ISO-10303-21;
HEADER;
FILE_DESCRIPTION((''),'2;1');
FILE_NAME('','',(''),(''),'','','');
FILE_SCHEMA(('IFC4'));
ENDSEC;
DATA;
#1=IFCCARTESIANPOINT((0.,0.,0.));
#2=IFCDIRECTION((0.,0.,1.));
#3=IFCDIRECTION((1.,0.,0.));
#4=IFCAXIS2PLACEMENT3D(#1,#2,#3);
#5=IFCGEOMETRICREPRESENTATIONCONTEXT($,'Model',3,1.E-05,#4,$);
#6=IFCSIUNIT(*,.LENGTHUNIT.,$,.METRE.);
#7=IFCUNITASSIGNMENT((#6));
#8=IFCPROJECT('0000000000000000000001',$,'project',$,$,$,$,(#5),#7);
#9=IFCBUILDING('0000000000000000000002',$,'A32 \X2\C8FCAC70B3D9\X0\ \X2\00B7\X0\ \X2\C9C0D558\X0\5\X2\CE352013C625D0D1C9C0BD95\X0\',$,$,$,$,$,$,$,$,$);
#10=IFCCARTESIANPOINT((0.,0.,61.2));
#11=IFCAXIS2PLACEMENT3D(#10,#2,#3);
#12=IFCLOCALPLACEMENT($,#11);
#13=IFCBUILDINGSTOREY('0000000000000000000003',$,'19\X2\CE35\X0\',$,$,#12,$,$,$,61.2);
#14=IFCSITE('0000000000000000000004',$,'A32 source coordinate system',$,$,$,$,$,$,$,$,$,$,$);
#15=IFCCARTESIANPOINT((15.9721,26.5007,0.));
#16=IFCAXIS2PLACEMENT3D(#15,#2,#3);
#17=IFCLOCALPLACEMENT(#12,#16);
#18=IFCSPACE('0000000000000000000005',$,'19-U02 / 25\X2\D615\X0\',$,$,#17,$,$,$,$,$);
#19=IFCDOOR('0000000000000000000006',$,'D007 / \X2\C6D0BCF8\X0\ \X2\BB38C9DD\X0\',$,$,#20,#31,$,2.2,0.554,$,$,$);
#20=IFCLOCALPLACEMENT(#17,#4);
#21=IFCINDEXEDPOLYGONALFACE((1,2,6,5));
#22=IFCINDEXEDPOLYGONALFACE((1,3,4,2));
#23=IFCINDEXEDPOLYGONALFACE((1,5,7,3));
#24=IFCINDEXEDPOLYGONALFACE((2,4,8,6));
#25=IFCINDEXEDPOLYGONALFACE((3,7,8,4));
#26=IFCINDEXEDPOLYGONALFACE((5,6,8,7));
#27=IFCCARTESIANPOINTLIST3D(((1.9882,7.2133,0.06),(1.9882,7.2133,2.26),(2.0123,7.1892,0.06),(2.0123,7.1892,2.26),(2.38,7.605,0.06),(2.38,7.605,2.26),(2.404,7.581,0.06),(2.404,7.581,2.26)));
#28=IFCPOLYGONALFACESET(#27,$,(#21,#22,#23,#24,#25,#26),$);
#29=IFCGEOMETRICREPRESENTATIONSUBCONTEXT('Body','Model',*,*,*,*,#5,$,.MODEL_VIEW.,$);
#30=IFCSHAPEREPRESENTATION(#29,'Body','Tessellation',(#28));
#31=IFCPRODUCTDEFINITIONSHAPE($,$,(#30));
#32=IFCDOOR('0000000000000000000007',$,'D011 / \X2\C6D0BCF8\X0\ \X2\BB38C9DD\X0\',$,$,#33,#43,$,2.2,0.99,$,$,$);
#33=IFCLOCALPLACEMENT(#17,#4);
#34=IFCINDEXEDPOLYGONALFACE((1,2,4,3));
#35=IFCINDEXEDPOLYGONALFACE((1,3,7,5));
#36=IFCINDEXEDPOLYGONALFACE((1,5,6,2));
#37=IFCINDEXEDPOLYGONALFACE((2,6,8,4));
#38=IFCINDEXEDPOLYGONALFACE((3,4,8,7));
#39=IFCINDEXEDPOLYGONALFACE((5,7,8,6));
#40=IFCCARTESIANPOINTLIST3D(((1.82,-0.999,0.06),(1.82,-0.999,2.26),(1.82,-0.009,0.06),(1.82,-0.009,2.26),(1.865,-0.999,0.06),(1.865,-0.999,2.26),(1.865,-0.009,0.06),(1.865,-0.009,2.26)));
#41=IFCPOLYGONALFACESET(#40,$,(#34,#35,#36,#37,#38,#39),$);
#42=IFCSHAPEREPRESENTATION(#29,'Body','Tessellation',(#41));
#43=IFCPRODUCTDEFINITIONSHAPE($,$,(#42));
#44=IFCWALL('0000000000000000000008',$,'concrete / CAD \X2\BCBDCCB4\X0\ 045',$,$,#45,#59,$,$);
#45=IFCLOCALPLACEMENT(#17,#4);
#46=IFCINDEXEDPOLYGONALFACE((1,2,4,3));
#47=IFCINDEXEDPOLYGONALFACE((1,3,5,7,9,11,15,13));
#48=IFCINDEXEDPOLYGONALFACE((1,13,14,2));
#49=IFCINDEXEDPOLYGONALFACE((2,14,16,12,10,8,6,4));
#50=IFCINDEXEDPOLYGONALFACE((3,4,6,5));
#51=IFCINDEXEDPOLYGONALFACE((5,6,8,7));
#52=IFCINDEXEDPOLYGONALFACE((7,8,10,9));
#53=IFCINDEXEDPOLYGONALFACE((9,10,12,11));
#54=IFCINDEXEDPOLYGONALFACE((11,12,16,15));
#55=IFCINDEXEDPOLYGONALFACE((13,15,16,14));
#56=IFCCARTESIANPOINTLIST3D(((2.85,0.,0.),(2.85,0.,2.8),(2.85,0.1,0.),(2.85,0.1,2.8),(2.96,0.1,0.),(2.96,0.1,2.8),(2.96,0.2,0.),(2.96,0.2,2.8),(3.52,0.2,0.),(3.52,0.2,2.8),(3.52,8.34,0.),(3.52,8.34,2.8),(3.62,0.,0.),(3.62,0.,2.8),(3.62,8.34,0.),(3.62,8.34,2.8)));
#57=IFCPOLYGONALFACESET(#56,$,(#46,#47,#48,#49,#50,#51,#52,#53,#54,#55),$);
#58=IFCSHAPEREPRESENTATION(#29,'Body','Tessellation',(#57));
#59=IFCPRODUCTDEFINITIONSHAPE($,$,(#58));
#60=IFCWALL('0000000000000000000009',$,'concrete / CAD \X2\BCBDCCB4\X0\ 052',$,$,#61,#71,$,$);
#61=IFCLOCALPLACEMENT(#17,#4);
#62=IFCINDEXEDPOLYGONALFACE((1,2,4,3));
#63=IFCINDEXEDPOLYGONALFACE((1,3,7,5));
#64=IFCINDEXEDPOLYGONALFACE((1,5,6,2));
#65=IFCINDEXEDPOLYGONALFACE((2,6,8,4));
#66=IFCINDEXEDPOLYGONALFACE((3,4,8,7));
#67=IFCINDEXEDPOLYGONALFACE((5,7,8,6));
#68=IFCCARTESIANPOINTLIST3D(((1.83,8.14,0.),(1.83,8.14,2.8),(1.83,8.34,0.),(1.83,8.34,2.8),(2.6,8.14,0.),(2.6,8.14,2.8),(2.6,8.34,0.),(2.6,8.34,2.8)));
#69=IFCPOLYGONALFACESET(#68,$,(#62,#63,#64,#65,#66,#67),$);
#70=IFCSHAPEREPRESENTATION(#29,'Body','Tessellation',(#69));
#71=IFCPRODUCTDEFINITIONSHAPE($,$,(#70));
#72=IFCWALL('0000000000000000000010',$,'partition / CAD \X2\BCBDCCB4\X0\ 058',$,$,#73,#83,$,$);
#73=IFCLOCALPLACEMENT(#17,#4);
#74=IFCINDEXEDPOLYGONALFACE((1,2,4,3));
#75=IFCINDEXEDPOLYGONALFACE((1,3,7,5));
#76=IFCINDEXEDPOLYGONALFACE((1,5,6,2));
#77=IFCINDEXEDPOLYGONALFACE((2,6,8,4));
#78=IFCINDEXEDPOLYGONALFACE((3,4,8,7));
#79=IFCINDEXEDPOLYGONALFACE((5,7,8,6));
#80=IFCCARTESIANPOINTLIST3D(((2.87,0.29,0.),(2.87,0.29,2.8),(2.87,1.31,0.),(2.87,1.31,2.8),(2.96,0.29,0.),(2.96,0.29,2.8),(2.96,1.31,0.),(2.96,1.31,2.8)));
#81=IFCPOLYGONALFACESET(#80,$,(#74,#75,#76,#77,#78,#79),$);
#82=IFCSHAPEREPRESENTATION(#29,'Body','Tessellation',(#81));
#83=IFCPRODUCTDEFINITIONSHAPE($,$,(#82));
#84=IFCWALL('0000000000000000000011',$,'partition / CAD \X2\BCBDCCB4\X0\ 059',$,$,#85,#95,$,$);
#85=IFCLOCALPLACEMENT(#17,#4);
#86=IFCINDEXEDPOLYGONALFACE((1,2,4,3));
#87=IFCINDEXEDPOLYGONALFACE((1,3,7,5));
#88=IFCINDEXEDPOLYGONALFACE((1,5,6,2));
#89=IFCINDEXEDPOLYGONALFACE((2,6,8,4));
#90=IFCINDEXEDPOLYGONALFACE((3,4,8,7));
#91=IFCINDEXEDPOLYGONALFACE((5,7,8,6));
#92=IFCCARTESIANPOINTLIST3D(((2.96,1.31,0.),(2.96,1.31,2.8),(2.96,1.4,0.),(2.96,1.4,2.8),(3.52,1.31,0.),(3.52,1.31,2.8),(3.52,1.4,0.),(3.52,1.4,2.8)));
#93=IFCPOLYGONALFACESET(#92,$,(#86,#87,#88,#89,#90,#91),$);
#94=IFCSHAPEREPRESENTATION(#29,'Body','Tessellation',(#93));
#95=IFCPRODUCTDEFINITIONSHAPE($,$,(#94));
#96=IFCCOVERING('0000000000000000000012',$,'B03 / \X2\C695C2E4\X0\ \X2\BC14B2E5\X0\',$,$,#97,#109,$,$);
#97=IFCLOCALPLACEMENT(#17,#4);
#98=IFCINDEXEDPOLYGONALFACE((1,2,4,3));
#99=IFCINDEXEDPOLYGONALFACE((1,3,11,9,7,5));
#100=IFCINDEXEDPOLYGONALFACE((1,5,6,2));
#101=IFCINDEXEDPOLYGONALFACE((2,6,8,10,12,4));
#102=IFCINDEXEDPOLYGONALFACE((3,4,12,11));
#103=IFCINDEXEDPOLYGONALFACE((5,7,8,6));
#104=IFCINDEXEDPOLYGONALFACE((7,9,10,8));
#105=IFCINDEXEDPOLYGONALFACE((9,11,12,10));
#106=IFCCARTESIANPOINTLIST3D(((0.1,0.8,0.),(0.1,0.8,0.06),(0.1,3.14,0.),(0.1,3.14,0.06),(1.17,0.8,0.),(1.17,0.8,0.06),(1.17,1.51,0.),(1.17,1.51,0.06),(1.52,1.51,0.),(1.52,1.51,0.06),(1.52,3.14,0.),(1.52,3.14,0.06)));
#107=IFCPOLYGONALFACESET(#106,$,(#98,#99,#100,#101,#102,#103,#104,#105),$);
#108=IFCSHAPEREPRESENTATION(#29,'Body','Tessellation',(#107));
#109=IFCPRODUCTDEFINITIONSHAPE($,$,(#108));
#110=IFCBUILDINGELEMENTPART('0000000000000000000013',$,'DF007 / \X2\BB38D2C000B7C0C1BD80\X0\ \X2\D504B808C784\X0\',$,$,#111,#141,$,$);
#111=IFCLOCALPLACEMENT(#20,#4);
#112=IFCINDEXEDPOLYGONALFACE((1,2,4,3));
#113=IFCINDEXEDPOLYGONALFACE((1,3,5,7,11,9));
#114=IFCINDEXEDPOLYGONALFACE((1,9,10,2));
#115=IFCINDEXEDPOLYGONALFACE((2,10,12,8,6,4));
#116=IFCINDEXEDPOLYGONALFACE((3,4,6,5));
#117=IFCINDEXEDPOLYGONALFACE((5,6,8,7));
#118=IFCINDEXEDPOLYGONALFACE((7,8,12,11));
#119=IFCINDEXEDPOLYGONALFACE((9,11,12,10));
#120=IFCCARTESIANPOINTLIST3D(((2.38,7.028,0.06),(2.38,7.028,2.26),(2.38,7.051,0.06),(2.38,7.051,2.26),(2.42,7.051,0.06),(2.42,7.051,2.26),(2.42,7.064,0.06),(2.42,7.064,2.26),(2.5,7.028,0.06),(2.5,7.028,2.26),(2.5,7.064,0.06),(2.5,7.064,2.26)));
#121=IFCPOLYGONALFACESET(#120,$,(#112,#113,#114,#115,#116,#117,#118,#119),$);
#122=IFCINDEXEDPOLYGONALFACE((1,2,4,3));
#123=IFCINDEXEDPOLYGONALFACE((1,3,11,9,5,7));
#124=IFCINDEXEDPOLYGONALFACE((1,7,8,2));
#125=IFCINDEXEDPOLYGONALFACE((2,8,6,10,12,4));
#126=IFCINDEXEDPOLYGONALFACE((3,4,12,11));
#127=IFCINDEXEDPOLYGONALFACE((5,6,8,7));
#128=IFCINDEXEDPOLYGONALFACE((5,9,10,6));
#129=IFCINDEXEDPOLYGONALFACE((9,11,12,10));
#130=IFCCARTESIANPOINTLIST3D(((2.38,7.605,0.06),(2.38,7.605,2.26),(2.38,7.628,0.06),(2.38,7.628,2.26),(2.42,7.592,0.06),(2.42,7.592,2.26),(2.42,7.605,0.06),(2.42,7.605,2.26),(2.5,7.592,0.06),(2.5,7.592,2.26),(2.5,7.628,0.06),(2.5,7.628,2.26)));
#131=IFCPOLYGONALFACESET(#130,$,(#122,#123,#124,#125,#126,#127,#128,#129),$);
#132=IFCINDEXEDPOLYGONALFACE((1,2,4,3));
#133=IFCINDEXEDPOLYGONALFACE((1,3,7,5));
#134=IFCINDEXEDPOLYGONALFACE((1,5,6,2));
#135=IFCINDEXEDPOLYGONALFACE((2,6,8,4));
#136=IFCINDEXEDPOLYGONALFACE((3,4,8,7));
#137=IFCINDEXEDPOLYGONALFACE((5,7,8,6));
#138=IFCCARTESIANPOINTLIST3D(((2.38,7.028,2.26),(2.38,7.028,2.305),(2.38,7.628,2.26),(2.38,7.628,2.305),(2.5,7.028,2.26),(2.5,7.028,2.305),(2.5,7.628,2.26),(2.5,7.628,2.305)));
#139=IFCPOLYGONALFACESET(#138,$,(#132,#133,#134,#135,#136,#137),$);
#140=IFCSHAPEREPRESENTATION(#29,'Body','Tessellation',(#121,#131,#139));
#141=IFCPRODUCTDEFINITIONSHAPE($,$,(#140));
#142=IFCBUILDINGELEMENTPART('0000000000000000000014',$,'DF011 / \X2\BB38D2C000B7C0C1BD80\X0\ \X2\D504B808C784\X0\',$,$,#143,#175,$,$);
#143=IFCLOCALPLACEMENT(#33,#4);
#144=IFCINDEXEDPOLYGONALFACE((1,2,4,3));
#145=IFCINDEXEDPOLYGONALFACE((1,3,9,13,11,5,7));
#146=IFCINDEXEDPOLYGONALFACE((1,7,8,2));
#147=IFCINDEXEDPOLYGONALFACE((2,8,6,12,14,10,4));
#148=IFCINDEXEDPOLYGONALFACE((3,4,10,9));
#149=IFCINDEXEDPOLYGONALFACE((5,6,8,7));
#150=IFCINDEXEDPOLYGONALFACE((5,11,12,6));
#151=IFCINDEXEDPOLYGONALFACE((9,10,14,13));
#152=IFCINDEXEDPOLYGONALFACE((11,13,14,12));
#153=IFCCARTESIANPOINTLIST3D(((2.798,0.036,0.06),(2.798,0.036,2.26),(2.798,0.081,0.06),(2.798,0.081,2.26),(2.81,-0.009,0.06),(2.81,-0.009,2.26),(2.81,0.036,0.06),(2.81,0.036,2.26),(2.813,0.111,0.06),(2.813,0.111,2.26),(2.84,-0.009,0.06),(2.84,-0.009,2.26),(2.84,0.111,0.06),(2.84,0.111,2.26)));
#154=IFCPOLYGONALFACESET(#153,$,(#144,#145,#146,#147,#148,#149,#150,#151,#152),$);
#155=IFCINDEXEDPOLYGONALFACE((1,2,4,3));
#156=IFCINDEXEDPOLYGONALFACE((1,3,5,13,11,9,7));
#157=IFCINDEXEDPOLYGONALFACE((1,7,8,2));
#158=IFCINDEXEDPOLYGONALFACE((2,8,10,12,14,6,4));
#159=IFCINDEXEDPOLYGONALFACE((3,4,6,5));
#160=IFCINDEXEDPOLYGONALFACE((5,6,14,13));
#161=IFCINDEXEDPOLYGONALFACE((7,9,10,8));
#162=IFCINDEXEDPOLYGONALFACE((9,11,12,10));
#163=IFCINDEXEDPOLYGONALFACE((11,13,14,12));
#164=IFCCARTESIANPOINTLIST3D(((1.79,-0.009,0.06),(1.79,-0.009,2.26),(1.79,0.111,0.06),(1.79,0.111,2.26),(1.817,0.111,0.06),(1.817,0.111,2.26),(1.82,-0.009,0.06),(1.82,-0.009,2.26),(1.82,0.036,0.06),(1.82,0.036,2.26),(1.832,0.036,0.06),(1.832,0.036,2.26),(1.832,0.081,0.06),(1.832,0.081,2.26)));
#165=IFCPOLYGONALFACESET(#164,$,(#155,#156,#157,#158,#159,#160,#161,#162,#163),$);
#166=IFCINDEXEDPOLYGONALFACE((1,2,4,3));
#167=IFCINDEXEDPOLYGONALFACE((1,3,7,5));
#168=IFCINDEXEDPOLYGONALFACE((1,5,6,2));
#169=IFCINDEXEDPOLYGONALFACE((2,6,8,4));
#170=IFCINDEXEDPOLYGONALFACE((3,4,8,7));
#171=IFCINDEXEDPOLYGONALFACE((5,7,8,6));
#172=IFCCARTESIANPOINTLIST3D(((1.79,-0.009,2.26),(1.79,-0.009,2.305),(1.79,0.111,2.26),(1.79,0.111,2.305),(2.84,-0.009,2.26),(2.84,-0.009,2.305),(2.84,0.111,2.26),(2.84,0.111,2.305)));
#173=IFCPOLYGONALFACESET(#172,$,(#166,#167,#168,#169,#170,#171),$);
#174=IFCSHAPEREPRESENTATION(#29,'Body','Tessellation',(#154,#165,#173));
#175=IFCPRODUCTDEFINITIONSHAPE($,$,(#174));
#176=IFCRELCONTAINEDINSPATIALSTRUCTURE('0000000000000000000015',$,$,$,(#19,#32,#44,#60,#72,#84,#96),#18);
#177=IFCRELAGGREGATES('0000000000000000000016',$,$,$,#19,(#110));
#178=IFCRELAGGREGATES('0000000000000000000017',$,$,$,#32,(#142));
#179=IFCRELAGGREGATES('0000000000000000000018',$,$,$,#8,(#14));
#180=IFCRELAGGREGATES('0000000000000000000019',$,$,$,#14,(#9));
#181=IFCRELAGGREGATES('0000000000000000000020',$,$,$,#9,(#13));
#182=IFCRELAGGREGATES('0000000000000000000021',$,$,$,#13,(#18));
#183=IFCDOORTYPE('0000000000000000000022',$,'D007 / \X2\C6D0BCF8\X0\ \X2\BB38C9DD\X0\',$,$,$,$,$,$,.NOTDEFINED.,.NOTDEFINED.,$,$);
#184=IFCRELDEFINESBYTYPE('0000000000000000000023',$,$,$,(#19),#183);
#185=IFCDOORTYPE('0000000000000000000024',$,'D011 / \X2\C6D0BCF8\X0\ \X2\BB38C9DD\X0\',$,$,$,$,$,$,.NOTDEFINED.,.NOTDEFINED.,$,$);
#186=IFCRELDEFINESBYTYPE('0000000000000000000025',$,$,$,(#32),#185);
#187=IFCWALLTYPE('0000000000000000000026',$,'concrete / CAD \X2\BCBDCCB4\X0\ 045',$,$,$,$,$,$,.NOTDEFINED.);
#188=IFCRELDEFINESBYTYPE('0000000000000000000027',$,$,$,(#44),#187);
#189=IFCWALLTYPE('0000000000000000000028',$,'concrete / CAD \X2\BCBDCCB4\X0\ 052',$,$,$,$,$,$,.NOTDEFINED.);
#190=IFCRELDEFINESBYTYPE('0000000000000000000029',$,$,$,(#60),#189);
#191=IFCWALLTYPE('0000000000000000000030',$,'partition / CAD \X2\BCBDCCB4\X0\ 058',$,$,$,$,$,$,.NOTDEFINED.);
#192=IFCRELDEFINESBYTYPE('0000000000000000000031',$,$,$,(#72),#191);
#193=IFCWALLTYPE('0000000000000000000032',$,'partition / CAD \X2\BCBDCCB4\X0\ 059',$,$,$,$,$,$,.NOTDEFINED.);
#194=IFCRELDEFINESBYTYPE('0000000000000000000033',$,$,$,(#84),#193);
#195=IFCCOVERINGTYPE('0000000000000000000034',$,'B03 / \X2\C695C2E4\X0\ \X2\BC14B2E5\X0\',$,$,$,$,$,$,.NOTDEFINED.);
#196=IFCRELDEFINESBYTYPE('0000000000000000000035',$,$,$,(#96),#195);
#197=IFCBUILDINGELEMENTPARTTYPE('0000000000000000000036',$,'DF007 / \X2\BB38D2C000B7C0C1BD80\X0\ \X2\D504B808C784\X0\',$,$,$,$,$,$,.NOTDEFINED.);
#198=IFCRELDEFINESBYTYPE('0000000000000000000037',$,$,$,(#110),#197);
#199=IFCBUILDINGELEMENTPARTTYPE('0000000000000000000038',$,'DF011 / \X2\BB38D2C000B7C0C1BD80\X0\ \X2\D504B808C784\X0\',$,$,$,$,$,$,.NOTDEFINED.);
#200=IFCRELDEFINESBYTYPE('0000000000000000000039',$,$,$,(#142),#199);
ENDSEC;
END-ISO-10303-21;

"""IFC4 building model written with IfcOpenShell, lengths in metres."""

from ifc_helpers import new_model, si_unit, frame, origin, origin_with_axes, place, context, subcontext, project, spatial, polyline, outline, extrude, source, transform, mapped, type_object, type_shapes, element, aggregate, save


model = new_model("IFC4")

# Units and contexts
model_context = context("Model", 3, precision=1e-05, world=origin_with_axes())
body_context = subcontext(model_context, "Body", "Model", "MODEL_VIEW")
ifc_project = project(units=[si_unit("LENGTHUNIT", "METRE")], contexts=[model_context])

# Site, building, storey, space
storey_placement = place(None, frame((0.0, 0.0, 61.2), z_axis=(0.0, 0.0, 1.0), x_axis=(1.0, 0.0, 0.0)))
space_placement = place(storey_placement, frame((15.9721, 26.5007, 0.0), z_axis=(0.0, 0.0, 1.0), x_axis=(1.0, 0.0, 0.0)))
site = spatial("IfcSite", under=ifc_project, Name="A32 source coordinate system")
building = spatial("IfcBuilding", under=site, Name="A32 주거동 · 지하5층–옥탑지붕")
storey = spatial("IfcBuildingStorey", under=building, at=storey_placement, Name="19층", Elevation=61.2)
space = spatial("IfcSpace", under=storey, at=space_placement, Name="19-U02 / 25형")

# Doors
door_type_1 = type_object("IfcDoorType", Name="D007 / 원본 문짝", OperationType="NOTDEFINED", PredefinedType="NOTDEFINED")
shared_shape_1 = source(origin(), body_context, "Body", "SweptSolid", [
    extrude(outline(polyline([(2.0123, 7.1892), (1.9882, 7.2133), (2.38, 7.605), (2.404, 7.581), (2.0123, 7.1892)])), frame((0.0, 0.0, 0.06)), (0.0, 0.0, 1.0), 2.2),
])
type_shapes(door_type_1, [shared_shape_1])
door_1_placement = place(space_placement, origin_with_axes())
door_1 = element("IfcDoor", 1, at=door_1_placement, inside=space, type_object=door_type_1, Name="D007 / 원본 문짝", OverallHeight=2.2, OverallWidth=0.554, context=body_context, shape_type="MappedRepresentation", body=[
    mapped(shared_shape_1, transform((0.0, 0.0, 0.0), scale=1.0)),
])
door_type_2 = type_object("IfcDoorType", Name="D011 / 원본 문짝", OperationType="NOTDEFINED", PredefinedType="NOTDEFINED")
shared_shape_2 = source(origin(), body_context, "Body", "SweptSolid", [
    extrude(outline(polyline([(1.865, -0.999), (1.82, -0.999), (1.82, -0.009), (1.865, -0.009), (1.865, -0.999)])), frame((0.0, 0.0, 0.06)), (0.0, 0.0, 1.0), 2.2),
])
type_shapes(door_type_2, [shared_shape_2])
door_2_placement = place(space_placement, origin_with_axes())
door_2 = element("IfcDoor", 2, at=door_2_placement, inside=space, type_object=door_type_2, Name="D011 / 원본 문짝", OverallHeight=2.2, OverallWidth=0.99, context=body_context, shape_type="MappedRepresentation", body=[
    mapped(shared_shape_2, transform((0.0, 0.0, 0.0), scale=1.0)),
])

# Walls
wall_type_1 = type_object("IfcWallType", Name="concrete / CAD 벽체 045", PredefinedType="NOTDEFINED")
shared_shape_3 = source(origin(), body_context, "Body", "SweptSolid", [
    extrude(outline(polyline([(2.96, 0.1), (2.96, 0.2), (3.52, 0.2), (3.52, 8.34), (3.72, 8.34), (3.72, 8.34), (3.62, 8.34), (3.62, 0.0), (2.85, 0.0), (2.85, 0.1), (2.96, 0.1)])), origin(), (0.0, 0.0, 1.0), 2.8),
])
type_shapes(wall_type_1, [shared_shape_3])
wall_1_placement = place(space_placement, origin_with_axes())
element("IfcWall", 3, at=wall_1_placement, inside=space, type_object=wall_type_1, Name="concrete / CAD 벽체 045", context=body_context, shape_type="MappedRepresentation", body=[
    mapped(shared_shape_3, transform((0.0, 0.0, 0.0), scale=1.0)),
])
wall_type_2 = type_object("IfcWallType", Name="concrete / CAD 벽체 052", PredefinedType="NOTDEFINED")
shared_shape_4 = source(origin(), body_context, "Body", "SweptSolid", [
    extrude(outline(polyline([(2.6, 8.14), (1.83, 8.14), (1.83, 8.34), (2.6, 8.34), (2.6, 8.14)])), origin(), (0.0, 0.0, 1.0), 2.8),
])
type_shapes(wall_type_2, [shared_shape_4])
wall_2_placement = place(space_placement, origin_with_axes())
element("IfcWall", 4, at=wall_2_placement, inside=space, type_object=wall_type_2, Name="concrete / CAD 벽체 052", context=body_context, shape_type="MappedRepresentation", body=[
    mapped(shared_shape_4, transform((0.0, 0.0, 0.0), scale=1.0)),
])
wall_type_3 = type_object("IfcWallType", Name="partition / CAD 벽체 058", PredefinedType="NOTDEFINED")
shared_shape_5 = source(origin(), body_context, "Body", "SweptSolid", [
    extrude(outline(polyline([(2.96, 1.31), (2.96, 0.29), (2.87, 0.29), (2.87, 1.31), (2.96, 1.31)])), origin(), (0.0, 0.0, 1.0), 2.8),
])
type_shapes(wall_type_3, [shared_shape_5])
wall_3_placement = place(space_placement, origin_with_axes())
element("IfcWall", 5, at=wall_3_placement, inside=space, type_object=wall_type_3, Name="partition / CAD 벽체 058", context=body_context, shape_type="MappedRepresentation", body=[
    mapped(shared_shape_5, transform((0.0, 0.0, 0.0), scale=1.0)),
])
wall_type_4 = type_object("IfcWallType", Name="partition / CAD 벽체 059", PredefinedType="NOTDEFINED")
shared_shape_6 = source(origin(), body_context, "Body", "SweptSolid", [
    extrude(outline(polyline([(3.52, 1.31), (2.96, 1.31), (2.96, 1.4), (3.52, 1.4), (3.52, 1.31)])), origin(), (0.0, 0.0, 1.0), 2.8),
])
type_shapes(wall_type_4, [shared_shape_6])
wall_4_placement = place(space_placement, origin_with_axes())
element("IfcWall", 6, at=wall_4_placement, inside=space, type_object=wall_type_4, Name="partition / CAD 벽체 059", context=body_context, shape_type="MappedRepresentation", body=[
    mapped(shared_shape_6, transform((0.0, 0.0, 0.0), scale=1.0)),
])

# Covering
covering_type_1 = type_object("IfcCoveringType", Name="B03 / 욕실 바닥", PredefinedType="NOTDEFINED")
shared_shape_7 = source(origin(), body_context, "Body", "SweptSolid", [
    extrude(outline(polyline([(1.17, 1.51), (1.17, 0.8), (0.1, 0.8), (0.1, 3.14), (1.52, 3.14), (1.52, 1.51), (1.17, 1.51)])), origin(), (0.0, 0.0, 1.0), 0.06),
])
type_shapes(covering_type_1, [shared_shape_7])
covering_1_placement = place(space_placement, origin_with_axes())
element("IfcCovering", 7, at=covering_1_placement, inside=space, type_object=covering_type_1, Name="B03 / 욕실 바닥", context=body_context, shape_type="MappedRepresentation", body=[
    mapped(shared_shape_7, transform((0.0, 0.0, 0.0), scale=1.0)),
])

# Building element parts
building_element_part_type_1 = type_object("IfcBuildingElementPartType", Name="DF007 / 문틀·상부 프레임", PredefinedType="NOTDEFINED")
shared_shape_8 = source(origin(), body_context, "Body", "SweptSolid", [
    extrude(outline(polyline([(2.38, 7.028), (2.38, 7.051), (2.42, 7.051), (2.42, 7.064), (2.5, 7.064), (2.5, 7.028), (2.38, 7.028)])), frame((0.0, 0.0, 0.06)), (0.0, 0.0, 1.0), 2.2),
    extrude(outline(polyline([(2.5, 7.592), (2.42, 7.592), (2.42, 7.605), (2.38, 7.605), (2.38, 7.628), (2.5, 7.628), (2.5, 7.592)])), frame((0.0, 0.0, 0.06)), (0.0, 0.0, 1.0), 2.2),
    extrude(outline(polyline([(2.38, 7.028), (2.38, 7.628), (2.5, 7.628), (2.5, 7.028), (2.38, 7.028)])), frame((0.0, 0.0, 2.26)), (0.0, 0.0, 1.0), 0.045),
])
type_shapes(building_element_part_type_1, [shared_shape_8])
building_element_part_1_placement = place(door_1_placement, origin_with_axes())
building_element_part_1 = element("IfcBuildingElementPart", 8, at=building_element_part_1_placement, type_object=building_element_part_type_1, Name="DF007 / 문틀·상부 프레임", context=body_context, shape_type="MappedRepresentation", body=[
    mapped(shared_shape_8, transform((0.0, 0.0, 0.0), scale=1.0)),
])
aggregate(door_1, [building_element_part_1])
building_element_part_type_2 = type_object("IfcBuildingElementPartType", Name="DF011 / 문틀·상부 프레임", PredefinedType="NOTDEFINED")
shared_shape_9 = source(origin(), body_context, "Body", "SweptSolid", [
    extrude(outline(polyline([(2.81, -0.009), (2.81, 0.036), (2.798, 0.036), (2.798, 0.081), (2.813, 0.111), (2.84, 0.111), (2.84, -0.009), (2.81, -0.009)])), frame((0.0, 0.0, 0.06)), (0.0, 0.0, 1.0), 2.2),
    extrude(outline(polyline([(1.79, 0.111), (1.817, 0.111), (1.832, 0.081), (1.832, 0.036), (1.82, 0.036), (1.82, -0.009), (1.79, -0.009), (1.79, 0.111)])), frame((0.0, 0.0, 0.06)), (0.0, 0.0, 1.0), 2.2),
    extrude(outline(polyline([(1.79, -0.009), (1.79, 0.111), (2.84, 0.111), (2.84, -0.009), (1.79, -0.009)])), frame((0.0, 0.0, 2.26)), (0.0, 0.0, 1.0), 0.045),
])
type_shapes(building_element_part_type_2, [shared_shape_9])
building_element_part_2_placement = place(door_2_placement, origin_with_axes())
building_element_part_2 = element("IfcBuildingElementPart", 9, at=building_element_part_2_placement, type_object=building_element_part_type_2, Name="DF011 / 문틀·상부 프레임", context=body_context, shape_type="MappedRepresentation", body=[
    mapped(shared_shape_9, transform((0.0, 0.0, 0.0), scale=1.0)),
])
aggregate(door_2, [building_element_part_2])

save(model, "model.ifc")
